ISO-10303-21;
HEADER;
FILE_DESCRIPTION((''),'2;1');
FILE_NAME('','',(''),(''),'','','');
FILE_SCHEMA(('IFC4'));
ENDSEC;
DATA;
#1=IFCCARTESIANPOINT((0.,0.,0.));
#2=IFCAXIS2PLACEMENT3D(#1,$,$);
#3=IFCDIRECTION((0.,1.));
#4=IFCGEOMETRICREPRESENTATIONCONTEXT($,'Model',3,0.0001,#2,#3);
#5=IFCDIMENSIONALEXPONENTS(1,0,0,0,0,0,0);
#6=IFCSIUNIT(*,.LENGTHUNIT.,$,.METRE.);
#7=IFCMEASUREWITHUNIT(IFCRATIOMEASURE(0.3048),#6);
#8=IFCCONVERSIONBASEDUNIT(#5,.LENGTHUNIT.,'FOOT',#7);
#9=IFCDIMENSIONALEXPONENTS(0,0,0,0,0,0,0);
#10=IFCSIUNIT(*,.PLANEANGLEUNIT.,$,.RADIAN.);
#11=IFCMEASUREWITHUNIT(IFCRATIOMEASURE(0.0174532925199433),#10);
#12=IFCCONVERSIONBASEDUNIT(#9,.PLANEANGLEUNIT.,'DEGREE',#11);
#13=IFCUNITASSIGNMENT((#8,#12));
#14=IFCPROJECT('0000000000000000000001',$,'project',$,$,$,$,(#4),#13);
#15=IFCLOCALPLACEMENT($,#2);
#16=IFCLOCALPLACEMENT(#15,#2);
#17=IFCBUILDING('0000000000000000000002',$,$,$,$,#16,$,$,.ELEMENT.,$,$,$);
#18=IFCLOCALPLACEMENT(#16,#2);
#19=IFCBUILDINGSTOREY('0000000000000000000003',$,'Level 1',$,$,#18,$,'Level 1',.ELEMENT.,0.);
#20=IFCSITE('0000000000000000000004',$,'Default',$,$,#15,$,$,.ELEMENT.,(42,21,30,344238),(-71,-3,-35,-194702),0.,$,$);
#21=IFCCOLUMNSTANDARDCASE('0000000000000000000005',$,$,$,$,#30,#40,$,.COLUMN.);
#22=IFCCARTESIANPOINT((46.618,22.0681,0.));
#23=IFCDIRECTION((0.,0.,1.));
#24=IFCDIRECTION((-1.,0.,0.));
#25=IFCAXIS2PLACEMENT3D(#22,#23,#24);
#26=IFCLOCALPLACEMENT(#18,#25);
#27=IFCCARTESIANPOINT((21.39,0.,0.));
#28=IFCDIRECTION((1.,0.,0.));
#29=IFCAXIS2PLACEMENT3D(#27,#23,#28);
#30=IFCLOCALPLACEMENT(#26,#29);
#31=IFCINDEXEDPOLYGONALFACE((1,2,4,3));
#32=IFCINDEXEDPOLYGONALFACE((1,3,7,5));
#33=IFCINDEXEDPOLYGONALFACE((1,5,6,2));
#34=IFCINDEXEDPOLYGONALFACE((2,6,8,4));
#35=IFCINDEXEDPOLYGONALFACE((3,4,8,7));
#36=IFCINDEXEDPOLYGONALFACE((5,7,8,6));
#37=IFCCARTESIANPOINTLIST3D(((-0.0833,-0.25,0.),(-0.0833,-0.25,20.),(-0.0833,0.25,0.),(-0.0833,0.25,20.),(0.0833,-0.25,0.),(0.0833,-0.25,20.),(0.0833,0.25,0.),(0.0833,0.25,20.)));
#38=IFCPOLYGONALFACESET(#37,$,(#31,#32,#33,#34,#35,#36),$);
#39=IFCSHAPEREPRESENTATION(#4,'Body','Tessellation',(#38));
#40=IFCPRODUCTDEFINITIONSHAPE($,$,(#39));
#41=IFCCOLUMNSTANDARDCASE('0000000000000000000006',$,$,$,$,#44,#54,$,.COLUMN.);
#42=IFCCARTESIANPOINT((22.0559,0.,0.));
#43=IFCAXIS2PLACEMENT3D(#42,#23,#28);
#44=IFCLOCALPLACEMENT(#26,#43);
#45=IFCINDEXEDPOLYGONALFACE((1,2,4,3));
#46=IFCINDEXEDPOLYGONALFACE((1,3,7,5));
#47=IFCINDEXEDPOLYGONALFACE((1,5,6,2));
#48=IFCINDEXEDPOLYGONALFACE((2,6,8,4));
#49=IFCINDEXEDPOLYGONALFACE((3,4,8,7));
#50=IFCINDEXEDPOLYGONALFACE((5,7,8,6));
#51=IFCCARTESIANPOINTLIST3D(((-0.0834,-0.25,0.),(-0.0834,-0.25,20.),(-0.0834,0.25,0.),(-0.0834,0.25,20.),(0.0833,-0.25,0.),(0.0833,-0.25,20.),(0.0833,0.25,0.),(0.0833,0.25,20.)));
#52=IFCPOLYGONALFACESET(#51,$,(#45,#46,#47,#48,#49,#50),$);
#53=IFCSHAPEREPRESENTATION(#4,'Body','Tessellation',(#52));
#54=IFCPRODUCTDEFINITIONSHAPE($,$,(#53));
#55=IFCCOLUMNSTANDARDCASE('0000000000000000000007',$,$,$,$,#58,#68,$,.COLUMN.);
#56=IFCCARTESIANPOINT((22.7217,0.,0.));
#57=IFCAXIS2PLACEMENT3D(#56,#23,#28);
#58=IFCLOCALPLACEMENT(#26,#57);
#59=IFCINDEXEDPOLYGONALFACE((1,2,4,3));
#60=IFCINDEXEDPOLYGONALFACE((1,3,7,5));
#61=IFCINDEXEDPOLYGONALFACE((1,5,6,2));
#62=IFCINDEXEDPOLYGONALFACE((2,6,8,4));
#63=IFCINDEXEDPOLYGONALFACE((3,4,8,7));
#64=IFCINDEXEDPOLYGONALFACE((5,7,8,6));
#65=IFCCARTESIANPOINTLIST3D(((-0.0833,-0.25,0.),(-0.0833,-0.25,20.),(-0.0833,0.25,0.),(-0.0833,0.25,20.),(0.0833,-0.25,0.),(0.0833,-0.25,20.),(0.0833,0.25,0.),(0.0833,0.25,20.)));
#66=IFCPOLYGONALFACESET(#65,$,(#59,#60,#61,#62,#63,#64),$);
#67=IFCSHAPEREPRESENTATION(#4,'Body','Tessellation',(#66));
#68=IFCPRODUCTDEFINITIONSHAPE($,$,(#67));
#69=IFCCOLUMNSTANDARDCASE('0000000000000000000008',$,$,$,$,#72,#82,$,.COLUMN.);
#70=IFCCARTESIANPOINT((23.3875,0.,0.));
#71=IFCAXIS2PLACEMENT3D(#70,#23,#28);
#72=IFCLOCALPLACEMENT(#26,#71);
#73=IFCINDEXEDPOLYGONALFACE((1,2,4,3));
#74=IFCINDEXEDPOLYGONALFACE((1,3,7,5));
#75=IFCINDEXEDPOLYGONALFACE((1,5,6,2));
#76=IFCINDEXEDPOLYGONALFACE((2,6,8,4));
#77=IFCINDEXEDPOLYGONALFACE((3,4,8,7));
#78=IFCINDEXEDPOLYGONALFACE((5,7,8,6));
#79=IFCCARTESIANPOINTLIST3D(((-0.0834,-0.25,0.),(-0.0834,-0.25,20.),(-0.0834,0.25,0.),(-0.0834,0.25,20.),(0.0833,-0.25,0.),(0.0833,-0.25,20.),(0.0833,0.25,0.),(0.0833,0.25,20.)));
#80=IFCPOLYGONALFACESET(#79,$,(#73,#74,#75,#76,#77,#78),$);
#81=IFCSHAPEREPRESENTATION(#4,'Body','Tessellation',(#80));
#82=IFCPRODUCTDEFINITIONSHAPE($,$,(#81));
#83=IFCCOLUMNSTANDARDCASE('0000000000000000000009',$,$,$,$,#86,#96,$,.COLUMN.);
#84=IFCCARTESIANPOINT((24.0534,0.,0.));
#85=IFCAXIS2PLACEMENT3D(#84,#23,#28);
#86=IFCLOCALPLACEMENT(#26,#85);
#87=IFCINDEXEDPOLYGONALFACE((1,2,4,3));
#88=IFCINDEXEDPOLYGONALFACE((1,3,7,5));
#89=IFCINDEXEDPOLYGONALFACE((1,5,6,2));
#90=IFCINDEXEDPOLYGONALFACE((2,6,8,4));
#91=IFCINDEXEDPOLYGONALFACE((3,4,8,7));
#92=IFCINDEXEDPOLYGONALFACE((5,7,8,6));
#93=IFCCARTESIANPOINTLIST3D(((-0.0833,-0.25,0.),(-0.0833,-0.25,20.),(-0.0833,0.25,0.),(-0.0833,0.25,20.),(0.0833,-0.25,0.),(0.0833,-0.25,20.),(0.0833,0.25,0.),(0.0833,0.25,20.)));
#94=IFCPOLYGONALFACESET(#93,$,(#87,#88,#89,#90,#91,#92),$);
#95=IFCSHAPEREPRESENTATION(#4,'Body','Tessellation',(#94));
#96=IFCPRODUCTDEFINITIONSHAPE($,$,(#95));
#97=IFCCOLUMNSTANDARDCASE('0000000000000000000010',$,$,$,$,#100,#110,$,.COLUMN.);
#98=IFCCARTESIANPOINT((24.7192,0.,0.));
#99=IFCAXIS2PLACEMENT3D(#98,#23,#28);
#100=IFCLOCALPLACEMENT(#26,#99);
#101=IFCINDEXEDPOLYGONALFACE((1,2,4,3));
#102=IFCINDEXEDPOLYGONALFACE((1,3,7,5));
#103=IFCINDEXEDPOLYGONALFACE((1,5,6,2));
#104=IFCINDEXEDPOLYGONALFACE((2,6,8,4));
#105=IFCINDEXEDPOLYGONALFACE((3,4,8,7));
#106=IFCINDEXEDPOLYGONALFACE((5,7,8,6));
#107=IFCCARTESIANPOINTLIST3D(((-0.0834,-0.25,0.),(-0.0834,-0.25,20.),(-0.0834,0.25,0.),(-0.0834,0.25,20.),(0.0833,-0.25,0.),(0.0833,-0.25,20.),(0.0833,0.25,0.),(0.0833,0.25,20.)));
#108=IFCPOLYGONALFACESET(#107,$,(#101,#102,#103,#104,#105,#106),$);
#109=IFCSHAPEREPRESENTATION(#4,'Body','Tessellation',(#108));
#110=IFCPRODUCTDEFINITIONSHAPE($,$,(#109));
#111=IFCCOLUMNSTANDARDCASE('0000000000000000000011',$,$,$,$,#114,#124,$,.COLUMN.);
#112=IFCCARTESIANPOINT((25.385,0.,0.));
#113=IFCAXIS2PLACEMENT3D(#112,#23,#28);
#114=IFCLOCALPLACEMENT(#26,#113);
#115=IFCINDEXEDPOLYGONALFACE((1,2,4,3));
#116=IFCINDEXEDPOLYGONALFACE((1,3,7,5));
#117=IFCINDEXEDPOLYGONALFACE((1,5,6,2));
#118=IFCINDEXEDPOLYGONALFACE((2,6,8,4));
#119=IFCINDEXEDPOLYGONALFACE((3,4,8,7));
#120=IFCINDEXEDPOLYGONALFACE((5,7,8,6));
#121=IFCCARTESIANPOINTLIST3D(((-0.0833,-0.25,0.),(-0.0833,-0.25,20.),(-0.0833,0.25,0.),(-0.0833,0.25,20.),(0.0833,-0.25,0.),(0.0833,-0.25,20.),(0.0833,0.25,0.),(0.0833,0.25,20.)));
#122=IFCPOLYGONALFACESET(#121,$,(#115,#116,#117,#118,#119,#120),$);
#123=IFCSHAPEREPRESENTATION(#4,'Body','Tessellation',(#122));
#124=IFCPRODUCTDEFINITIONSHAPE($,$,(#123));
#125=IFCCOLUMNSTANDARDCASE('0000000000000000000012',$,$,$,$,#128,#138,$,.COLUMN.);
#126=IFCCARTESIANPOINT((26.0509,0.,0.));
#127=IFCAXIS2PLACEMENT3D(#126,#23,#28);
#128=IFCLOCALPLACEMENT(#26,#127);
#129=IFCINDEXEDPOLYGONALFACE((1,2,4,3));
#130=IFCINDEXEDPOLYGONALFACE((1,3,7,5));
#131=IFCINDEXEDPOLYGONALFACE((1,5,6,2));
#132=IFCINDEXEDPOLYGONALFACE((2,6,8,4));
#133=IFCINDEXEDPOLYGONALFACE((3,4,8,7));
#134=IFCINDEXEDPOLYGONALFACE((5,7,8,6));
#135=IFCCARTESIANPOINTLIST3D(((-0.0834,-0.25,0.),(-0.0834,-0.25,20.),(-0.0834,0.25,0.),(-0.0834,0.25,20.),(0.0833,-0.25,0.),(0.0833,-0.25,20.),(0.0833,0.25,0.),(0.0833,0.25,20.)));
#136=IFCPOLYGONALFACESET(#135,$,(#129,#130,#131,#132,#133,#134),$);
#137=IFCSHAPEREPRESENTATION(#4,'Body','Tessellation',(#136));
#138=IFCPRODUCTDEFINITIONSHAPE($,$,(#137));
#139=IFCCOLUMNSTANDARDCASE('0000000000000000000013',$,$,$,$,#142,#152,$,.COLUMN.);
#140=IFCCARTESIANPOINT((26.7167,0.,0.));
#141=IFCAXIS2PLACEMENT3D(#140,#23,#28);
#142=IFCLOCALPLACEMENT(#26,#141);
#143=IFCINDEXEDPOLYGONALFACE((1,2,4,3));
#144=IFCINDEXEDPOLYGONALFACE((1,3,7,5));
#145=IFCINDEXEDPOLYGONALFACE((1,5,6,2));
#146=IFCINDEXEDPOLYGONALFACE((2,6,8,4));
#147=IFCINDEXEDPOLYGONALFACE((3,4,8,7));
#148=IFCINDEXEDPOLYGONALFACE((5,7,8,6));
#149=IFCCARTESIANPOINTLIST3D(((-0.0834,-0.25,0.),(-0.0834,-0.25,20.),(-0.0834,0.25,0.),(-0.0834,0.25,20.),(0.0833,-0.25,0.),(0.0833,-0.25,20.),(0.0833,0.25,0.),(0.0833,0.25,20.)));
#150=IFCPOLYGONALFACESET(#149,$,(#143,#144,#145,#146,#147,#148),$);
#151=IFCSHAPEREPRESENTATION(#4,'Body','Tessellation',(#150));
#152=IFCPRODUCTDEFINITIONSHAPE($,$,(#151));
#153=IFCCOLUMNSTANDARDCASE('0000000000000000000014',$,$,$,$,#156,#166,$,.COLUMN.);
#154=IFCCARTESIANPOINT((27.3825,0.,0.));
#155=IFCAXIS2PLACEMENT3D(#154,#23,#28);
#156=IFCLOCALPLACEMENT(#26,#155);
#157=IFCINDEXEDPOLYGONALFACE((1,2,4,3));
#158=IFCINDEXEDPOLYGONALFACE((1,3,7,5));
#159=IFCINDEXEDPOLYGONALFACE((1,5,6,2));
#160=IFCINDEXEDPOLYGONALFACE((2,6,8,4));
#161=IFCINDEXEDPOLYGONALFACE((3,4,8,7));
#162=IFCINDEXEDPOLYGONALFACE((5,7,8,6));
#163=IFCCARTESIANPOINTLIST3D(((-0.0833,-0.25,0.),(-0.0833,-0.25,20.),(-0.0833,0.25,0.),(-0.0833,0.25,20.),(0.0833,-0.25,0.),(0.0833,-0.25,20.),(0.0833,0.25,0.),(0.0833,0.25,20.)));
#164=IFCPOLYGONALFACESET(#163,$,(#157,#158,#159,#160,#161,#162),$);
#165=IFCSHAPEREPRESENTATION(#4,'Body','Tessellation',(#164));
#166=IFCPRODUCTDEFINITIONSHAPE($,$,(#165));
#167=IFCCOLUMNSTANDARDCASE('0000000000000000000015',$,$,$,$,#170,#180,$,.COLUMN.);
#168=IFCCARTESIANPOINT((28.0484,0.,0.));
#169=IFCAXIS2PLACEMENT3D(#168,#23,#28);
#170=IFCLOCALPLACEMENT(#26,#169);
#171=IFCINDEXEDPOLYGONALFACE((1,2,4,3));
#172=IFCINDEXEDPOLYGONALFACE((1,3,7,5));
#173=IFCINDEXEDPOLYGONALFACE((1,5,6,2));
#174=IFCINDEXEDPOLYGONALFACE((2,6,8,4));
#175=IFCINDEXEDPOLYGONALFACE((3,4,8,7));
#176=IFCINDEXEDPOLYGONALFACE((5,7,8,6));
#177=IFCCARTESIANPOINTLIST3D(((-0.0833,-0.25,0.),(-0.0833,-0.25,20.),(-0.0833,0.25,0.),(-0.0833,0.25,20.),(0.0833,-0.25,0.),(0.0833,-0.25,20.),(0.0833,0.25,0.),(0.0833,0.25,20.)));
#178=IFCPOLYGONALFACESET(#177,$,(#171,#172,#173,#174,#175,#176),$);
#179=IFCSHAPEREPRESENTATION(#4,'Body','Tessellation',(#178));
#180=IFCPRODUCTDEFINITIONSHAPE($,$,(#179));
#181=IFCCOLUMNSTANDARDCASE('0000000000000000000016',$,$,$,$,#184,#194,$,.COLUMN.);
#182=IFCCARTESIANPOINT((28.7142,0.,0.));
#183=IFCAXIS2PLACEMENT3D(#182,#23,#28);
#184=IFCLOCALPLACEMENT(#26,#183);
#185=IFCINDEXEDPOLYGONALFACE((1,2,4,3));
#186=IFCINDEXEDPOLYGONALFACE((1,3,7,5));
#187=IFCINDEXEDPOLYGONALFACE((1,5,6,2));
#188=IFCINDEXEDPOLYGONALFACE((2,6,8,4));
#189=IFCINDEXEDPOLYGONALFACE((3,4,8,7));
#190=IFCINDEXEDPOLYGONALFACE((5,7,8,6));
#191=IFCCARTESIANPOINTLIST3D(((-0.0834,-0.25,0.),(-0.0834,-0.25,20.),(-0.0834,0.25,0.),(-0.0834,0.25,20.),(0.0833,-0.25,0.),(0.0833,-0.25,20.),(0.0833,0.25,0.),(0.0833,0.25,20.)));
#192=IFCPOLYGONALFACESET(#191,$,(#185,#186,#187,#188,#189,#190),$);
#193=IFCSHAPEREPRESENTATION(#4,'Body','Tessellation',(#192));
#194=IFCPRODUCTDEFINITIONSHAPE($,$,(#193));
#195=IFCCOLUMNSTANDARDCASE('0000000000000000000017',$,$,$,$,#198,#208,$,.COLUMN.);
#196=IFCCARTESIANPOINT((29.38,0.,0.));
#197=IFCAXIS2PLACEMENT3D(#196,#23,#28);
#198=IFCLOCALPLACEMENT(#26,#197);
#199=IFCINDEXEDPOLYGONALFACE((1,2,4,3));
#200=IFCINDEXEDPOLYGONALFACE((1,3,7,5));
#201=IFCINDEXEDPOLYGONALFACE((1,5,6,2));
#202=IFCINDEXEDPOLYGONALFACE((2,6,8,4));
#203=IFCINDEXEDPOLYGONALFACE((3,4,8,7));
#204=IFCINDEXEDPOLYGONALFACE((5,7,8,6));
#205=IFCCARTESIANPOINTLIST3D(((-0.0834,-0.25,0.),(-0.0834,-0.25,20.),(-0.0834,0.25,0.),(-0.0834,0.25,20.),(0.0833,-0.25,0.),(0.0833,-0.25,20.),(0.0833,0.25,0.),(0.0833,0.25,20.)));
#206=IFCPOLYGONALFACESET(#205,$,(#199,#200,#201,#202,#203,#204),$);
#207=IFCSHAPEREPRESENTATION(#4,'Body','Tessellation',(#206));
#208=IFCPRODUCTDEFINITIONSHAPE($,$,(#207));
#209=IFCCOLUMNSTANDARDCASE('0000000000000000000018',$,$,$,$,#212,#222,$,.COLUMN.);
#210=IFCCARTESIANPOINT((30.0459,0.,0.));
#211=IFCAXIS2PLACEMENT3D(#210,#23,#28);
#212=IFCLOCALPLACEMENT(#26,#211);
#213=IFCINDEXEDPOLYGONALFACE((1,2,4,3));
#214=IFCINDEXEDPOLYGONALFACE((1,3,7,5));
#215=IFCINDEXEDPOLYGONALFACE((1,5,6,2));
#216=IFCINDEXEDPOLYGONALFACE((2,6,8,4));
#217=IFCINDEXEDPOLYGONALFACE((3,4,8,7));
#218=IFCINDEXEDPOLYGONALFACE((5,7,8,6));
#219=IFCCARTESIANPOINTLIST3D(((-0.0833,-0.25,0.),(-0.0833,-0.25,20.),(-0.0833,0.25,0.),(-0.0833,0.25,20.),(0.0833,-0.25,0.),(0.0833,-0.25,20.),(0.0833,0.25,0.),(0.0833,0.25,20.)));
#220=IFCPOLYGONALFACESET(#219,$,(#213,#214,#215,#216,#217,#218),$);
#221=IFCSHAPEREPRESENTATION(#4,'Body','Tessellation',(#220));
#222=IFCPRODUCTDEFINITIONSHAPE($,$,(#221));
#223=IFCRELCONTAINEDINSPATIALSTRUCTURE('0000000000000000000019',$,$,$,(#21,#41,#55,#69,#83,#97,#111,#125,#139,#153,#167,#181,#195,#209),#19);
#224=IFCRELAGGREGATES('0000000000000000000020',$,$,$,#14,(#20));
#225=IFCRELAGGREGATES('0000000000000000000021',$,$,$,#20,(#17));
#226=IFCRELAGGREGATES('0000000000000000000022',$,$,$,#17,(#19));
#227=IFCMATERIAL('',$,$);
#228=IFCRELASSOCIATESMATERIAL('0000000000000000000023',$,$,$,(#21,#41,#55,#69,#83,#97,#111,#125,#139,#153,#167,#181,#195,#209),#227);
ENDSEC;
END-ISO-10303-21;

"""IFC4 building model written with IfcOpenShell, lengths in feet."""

from ifc_helpers import new_model, entity, si_unit, converted_unit, direction, frame, origin, place, context, project, spatial, rectangle, extrude, material, element, save


model = new_model("IFC4")

# Units and contexts
model_context = context("Model", 3, precision=0.0001, world=origin(), true_north=direction((0.0, 1.0)))
ifc_project = project(units=[converted_unit("LENGTHUNIT", "FOOT", entity("IfcRatioMeasure", 0.3048), si_unit("LENGTHUNIT", "METRE"), dimensions=[1, 0, 0, 0, 0, 0, 0]), converted_unit("PLANEANGLEUNIT", "DEGREE", entity("IfcRatioMeasure", 0.0174532925199433), si_unit("PLANEANGLEUNIT", "RADIAN"), dimensions=[0, 0, 0, 0, 0, 0, 0])], contexts=[model_context])

# Site, building, storey
site_placement = place(None, origin())
site = spatial("IfcSite", under=ifc_project, at=site_placement, Name="Default", CompositionType="ELEMENT", RefLatitude=(42, 21, 30, 344238), RefLongitude=(-71, -3, -35, -194702), RefElevation=0.0)
building_placement = place(site_placement, origin())
building = spatial("IfcBuilding", under=site, at=building_placement, CompositionType="ELEMENT")
storey_placement = place(building_placement, origin())
storey = spatial("IfcBuildingStorey", under=building, at=storey_placement, Name="Level 1", LongName="Level 1", CompositionType="ELEMENT", Elevation=0.0)

# Columns
ifc_material = material(Name="")
placement = place(storey_placement, frame((46.618, 22.0681, 0.0), z_axis=(0.0, 0.0, 1.0), x_axis=(-1.0, 0.0, 0.0)))
for number, where, z_axis, x_axis in (
    (1, (21.39, 0.0, 0.0), (0.0, 0.0, 1.0), (1.0, 0.0, 0.0)),
    (2, (22.0559, 0.0, 0.0), (0.0, 0.0, 1.0), (1.0, 0.0, 0.0)),
    (3, (22.7217, 0.0, 0.0), (0.0, 0.0, 1.0), (1.0, 0.0, 0.0)),
    (4, (23.3875, 0.0, 0.0), (0.0, 0.0, 1.0), (1.0, 0.0, 0.0)),
    (5, (24.0534, 0.0, 0.0), (0.0, 0.0, 1.0), (1.0, 0.0, 0.0)),
    (6, (24.7192, 0.0, 0.0), (0.0, 0.0, 1.0), (1.0, 0.0, 0.0)),
    (7, (25.385, 0.0, 0.0), (0.0, 0.0, 1.0), (1.0, 0.0, 0.0)),
    (8, (26.0509, 0.0, 0.0), (0.0, 0.0, 1.0), (1.0, 0.0, 0.0)),
    (9, (26.7167, 0.0, 0.0), (0.0, 0.0, 1.0), (1.0, 0.0, 0.0)),
    (10, (27.3825, 0.0, 0.0), (0.0, 0.0, 1.0), (1.0, 0.0, 0.0)),
    (11, (28.0484, 0.0, 0.0), (0.0, 0.0, 1.0), (1.0, 0.0, 0.0)),
    (12, (28.7142, 0.0, 0.0), (0.0, 0.0, 1.0), (1.0, 0.0, 0.0)),
    (13, (29.38, 0.0, 0.0), (0.0, 0.0, 1.0), (1.0, 0.0, 0.0)),
    (14, (30.0459, 0.0, 0.0), (0.0, 0.0, 1.0), (1.0, 0.0, 0.0)),
):
    element("IfcColumnStandardCase", number, at=place(placement, frame(where, z_axis=z_axis, x_axis=x_axis)), inside=storey, material=ifc_material, PredefinedType="COLUMN", context=model_context, shape_type="SweptSolid", body=[
        extrude(rectangle(XDim=0.1667, YDim=0.5), origin(), (0.0, 0.0, 1.0), 20.0),
    ])

save(model, "model.ifc")
